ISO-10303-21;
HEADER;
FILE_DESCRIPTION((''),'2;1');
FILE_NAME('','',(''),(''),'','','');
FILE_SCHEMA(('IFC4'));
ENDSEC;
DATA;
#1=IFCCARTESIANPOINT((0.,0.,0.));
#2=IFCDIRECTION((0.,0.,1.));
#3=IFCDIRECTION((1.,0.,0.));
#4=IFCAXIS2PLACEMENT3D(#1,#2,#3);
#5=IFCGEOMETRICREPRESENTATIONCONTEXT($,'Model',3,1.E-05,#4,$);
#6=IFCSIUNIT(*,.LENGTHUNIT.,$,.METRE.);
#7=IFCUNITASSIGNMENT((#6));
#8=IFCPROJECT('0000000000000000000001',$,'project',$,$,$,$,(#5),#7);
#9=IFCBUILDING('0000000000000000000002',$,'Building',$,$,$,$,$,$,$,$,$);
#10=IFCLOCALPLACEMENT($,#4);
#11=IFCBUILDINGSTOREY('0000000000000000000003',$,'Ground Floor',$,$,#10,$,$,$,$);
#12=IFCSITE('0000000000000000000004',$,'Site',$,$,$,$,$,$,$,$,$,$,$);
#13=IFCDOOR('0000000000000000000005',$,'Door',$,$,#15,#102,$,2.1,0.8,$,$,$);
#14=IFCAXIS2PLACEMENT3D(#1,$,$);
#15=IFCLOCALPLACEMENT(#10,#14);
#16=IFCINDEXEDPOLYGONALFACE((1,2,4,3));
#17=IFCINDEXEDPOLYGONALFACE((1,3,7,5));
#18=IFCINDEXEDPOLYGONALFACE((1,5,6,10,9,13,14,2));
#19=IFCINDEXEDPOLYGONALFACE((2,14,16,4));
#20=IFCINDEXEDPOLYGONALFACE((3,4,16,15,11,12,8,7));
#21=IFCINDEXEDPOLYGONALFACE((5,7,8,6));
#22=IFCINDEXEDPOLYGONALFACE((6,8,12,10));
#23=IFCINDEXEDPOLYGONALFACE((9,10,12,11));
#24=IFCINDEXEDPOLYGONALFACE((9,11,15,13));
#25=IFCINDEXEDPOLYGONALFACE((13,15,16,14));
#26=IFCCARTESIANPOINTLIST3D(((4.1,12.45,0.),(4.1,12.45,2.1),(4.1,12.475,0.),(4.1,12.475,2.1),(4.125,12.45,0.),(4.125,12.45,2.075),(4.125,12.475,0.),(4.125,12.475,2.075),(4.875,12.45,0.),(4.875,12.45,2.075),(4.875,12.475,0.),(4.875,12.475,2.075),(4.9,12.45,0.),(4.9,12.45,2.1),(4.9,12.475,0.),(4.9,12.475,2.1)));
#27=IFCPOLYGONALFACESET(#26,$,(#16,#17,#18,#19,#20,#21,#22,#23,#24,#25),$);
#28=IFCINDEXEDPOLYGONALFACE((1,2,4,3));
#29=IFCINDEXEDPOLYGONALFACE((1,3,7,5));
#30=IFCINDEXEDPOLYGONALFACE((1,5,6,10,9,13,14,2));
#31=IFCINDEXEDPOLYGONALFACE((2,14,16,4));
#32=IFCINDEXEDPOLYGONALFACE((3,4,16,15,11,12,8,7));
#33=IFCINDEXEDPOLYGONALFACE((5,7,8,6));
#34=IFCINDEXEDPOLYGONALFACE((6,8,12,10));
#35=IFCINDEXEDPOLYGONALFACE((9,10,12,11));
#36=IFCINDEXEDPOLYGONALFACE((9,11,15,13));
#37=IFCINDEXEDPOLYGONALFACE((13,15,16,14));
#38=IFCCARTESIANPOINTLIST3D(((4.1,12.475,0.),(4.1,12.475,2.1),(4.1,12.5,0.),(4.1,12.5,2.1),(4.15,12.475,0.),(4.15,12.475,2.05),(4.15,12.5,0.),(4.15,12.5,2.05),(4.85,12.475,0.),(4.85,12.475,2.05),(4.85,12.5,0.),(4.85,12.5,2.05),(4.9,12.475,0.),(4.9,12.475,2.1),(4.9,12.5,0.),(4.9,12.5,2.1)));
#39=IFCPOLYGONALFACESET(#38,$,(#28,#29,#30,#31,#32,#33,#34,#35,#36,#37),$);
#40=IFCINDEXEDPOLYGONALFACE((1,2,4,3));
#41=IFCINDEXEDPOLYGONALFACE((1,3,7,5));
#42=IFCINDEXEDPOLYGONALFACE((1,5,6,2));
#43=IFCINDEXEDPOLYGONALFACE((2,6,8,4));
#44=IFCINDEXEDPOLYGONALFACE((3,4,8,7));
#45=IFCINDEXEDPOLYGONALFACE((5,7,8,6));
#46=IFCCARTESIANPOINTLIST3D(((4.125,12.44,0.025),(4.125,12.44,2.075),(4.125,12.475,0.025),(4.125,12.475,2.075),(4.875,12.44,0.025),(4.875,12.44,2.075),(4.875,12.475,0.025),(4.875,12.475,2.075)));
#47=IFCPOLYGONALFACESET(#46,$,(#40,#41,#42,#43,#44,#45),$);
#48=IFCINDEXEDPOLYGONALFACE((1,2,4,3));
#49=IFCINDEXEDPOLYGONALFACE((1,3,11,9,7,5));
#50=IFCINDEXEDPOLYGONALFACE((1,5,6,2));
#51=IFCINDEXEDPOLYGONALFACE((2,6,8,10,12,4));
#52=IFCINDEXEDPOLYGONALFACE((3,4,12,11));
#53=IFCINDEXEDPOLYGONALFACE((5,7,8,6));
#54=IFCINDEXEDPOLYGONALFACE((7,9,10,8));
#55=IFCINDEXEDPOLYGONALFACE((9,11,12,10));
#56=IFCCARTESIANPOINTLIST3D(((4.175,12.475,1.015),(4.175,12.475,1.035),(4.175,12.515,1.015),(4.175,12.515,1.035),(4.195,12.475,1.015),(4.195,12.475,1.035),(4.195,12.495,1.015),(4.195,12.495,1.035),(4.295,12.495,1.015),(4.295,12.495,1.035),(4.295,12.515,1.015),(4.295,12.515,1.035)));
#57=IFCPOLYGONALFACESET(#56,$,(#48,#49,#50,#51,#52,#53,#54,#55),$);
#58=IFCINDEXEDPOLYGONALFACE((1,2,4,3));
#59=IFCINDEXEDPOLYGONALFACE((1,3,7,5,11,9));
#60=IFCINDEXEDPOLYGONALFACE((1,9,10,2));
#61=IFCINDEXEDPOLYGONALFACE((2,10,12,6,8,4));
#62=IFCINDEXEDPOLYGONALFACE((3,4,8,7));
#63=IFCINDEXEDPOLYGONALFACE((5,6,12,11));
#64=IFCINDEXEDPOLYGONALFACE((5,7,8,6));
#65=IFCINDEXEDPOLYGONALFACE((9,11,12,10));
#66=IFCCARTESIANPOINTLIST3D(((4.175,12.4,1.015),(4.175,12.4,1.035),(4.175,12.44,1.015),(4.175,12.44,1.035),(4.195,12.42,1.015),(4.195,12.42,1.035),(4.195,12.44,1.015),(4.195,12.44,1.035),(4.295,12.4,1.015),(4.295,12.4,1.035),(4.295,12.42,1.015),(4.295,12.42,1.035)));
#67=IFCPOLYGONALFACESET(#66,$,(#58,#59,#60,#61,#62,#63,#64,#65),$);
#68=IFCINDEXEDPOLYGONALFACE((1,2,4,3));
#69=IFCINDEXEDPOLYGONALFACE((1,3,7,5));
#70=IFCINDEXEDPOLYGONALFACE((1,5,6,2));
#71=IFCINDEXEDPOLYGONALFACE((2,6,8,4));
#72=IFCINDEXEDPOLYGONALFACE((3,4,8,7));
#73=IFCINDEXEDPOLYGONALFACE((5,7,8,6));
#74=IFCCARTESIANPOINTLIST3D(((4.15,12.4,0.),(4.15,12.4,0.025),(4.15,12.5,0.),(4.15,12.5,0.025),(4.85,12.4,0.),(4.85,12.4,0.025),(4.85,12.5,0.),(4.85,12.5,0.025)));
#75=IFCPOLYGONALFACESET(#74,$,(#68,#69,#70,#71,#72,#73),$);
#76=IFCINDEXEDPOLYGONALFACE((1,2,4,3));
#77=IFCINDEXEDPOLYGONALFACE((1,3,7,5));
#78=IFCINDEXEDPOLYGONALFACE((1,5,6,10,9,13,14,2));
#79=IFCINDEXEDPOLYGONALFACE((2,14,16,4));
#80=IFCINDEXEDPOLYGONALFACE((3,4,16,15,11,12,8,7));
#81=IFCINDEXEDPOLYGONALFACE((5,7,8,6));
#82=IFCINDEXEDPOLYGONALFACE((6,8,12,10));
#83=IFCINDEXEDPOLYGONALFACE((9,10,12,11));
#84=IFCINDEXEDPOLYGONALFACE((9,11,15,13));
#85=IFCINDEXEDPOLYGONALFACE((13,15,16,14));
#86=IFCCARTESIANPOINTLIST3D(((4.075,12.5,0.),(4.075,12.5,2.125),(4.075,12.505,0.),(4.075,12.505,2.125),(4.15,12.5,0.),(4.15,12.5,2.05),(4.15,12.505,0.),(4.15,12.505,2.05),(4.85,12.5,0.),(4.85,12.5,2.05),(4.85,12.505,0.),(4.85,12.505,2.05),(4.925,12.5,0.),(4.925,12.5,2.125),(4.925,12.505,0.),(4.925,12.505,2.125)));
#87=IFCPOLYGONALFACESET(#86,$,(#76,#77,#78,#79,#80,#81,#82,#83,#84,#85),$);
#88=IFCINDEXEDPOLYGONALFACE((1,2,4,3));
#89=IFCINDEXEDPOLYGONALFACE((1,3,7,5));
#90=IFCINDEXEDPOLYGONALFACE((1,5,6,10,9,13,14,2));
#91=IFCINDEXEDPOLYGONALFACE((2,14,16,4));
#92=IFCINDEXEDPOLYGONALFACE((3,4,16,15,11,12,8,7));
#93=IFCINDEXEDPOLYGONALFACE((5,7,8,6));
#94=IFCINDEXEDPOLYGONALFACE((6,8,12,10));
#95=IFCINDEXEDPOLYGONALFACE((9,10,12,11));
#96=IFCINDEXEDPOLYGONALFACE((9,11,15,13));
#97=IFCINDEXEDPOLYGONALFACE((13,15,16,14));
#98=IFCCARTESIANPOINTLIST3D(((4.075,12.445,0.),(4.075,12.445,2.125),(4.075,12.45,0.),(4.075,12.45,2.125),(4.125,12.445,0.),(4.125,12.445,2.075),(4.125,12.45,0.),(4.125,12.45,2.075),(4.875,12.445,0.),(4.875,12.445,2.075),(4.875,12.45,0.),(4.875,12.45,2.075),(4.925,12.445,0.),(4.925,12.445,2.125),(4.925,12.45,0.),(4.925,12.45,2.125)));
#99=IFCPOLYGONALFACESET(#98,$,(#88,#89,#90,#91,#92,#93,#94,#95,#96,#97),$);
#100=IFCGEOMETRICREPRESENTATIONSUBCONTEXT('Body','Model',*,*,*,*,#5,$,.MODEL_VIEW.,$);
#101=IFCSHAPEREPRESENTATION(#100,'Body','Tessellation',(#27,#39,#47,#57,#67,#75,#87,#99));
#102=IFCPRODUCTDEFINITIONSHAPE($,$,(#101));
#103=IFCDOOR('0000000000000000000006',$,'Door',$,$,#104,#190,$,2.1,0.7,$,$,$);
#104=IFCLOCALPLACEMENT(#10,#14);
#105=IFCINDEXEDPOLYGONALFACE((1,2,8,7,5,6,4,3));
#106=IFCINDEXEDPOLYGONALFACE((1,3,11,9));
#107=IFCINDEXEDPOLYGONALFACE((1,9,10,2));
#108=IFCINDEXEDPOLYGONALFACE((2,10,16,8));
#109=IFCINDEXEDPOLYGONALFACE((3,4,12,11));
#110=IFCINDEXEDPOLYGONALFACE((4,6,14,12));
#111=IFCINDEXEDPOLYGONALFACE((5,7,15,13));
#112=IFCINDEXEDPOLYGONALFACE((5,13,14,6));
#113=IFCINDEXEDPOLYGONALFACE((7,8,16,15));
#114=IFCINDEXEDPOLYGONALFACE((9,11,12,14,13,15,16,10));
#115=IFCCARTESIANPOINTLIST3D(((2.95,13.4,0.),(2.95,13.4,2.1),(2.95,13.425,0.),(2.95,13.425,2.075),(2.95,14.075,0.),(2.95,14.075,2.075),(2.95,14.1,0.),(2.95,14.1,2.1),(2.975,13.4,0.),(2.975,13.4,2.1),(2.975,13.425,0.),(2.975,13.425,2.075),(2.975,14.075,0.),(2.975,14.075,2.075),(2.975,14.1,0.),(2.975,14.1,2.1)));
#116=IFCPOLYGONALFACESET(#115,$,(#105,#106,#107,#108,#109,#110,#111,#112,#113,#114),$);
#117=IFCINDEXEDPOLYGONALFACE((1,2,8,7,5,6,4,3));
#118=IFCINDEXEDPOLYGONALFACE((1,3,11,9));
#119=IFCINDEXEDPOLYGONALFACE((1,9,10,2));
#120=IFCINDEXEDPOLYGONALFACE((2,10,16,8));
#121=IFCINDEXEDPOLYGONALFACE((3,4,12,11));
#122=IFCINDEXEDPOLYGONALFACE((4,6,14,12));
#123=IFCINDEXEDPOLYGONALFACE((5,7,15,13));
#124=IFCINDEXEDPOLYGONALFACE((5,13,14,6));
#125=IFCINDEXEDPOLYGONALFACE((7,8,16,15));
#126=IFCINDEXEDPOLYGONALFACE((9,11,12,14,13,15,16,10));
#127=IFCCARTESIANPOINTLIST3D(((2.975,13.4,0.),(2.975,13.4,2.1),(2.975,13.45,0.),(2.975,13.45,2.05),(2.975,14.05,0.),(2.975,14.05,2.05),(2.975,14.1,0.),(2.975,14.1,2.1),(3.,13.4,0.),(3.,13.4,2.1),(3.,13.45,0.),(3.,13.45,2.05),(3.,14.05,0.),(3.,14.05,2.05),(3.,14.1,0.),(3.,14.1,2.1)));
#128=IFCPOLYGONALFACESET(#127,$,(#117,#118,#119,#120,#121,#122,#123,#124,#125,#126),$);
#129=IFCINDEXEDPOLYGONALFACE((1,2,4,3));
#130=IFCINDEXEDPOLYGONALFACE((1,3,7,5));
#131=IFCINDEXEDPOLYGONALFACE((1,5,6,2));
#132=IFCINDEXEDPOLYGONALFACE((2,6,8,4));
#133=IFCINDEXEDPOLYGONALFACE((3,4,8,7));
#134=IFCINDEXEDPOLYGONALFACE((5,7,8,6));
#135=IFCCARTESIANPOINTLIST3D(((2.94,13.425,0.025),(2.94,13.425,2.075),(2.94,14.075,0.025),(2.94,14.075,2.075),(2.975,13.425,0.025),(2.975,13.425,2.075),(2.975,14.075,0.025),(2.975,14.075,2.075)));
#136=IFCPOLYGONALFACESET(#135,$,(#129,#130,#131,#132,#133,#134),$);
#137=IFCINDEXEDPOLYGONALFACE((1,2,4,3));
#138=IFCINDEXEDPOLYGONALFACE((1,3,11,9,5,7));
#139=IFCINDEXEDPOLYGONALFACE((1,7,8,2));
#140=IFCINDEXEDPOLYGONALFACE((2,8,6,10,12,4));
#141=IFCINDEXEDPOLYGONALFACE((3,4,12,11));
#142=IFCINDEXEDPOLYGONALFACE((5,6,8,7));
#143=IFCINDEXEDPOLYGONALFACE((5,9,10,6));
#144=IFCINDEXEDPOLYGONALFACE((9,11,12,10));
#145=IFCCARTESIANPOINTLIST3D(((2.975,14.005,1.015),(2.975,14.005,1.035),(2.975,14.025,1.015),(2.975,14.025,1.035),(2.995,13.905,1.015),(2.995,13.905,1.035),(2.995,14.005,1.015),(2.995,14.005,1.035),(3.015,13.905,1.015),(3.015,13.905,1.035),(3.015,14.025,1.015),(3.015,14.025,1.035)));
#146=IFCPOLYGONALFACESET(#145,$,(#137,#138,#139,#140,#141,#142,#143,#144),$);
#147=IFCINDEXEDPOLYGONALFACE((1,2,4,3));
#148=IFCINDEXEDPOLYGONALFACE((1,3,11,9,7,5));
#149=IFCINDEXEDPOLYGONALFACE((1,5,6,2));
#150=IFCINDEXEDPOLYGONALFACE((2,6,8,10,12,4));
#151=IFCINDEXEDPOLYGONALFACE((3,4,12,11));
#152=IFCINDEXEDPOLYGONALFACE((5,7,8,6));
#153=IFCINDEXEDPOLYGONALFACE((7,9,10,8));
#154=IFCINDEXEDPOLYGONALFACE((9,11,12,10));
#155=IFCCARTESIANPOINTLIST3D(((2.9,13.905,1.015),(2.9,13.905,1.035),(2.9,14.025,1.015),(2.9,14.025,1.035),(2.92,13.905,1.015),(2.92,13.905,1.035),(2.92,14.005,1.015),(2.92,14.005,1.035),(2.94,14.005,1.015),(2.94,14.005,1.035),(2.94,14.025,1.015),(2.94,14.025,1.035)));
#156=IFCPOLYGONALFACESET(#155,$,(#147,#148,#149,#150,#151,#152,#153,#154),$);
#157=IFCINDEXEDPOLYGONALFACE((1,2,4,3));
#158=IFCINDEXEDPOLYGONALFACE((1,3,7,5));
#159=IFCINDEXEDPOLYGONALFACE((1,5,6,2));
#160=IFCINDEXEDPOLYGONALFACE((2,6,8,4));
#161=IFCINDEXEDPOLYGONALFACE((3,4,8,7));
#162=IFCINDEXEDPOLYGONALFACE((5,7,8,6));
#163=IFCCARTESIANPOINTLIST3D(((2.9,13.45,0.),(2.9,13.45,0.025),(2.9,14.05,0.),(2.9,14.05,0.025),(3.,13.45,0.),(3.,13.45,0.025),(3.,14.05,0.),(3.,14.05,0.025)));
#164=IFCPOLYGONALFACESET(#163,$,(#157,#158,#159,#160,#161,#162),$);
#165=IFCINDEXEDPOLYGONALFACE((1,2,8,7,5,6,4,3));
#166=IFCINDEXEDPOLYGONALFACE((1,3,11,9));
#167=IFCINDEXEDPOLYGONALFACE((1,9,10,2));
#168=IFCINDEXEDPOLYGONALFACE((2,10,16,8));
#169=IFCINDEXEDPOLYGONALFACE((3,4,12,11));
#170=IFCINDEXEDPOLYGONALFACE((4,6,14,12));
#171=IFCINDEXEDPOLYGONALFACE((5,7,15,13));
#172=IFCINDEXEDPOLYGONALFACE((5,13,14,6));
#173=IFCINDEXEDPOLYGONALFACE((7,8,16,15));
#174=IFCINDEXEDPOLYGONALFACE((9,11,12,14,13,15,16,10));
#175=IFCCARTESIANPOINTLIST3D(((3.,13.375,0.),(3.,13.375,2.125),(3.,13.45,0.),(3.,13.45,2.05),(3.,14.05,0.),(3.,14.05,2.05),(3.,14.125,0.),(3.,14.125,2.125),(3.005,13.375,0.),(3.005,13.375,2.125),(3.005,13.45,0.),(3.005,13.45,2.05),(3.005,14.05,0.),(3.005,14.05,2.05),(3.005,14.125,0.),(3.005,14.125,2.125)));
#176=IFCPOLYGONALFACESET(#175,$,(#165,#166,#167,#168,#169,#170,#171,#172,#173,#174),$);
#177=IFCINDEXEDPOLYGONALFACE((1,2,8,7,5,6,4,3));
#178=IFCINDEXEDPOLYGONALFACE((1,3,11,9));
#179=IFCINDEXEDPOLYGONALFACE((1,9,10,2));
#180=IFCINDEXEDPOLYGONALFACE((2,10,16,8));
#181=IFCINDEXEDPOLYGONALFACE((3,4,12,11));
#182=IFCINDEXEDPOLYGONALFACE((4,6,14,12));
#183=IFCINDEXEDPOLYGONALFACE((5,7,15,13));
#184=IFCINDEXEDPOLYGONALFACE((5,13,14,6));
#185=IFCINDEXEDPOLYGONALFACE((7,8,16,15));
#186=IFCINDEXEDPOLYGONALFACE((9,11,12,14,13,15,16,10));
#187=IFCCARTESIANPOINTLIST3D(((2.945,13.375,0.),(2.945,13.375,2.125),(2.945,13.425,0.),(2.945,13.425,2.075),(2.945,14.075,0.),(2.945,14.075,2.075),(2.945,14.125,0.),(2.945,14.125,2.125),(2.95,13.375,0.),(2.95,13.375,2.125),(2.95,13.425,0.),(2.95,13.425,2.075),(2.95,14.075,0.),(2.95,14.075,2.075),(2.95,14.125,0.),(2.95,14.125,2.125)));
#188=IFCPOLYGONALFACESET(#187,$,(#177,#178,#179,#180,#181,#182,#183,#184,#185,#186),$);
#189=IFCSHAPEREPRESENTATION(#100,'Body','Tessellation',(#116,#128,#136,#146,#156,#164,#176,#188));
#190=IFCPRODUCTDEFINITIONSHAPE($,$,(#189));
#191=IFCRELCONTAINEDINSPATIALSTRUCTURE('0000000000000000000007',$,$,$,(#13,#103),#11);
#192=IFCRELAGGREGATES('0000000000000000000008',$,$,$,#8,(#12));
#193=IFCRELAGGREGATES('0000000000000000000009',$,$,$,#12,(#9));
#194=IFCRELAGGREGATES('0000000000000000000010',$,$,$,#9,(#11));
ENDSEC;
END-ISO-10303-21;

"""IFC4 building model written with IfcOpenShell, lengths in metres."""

from ifc_helpers import new_model, si_unit, frame, origin_with_axes, place, context, subcontext, project, spatial, line, indexed_curve, outline, extrude, element, save


model = new_model("IFC4")

# Units and contexts
model_context = context("Model", 3, precision=1e-05, world=origin_with_axes())
body_context = subcontext(model_context, "Body", "Model", "MODEL_VIEW")
ifc_project = project(units=[si_unit("LENGTHUNIT", "METRE")], contexts=[model_context])

# Site, building, storey
site = spatial("IfcSite", under=ifc_project, Name="Site")
building = spatial("IfcBuilding", under=site, Name="Building")
storey_placement = place(None, origin_with_axes())
storey = spatial("IfcBuildingStorey", under=building, at=storey_placement, Name="Ground Floor")

# Doors
door_1_placement = place(storey_placement, frame((4.9, 12.5, 0.0), z_axis=(0.0, 0.0, 1.0), x_axis=(-1.0, 0.0, 0.0)))
element("IfcDoor", 1, at=door_1_placement, inside=storey, Name="Door", OverallHeight=2.1, OverallWidth=0.8, context=body_context, shape_type="SweptSolid", body=[
    extrude(outline(indexed_curve([(0.0, 0.0), (0.0, 2.1), (0.8, 2.1), (0.8, 0.0), (0.775, 0.0), (0.775, 2.075), (0.025, 2.075), (0.025, 0.0)], segments=[line(1, 2, 3, 4, 5, 6, 7, 8, 1)])), frame((0.0, 0.025, 0.0), z_axis=(0.0, -1.0, 0.0), x_axis=(1.0, 0.0, 0.0)), (0.0, 0.0, -1.0), 0.025),
    extrude(outline(indexed_curve([(0.0, 0.0), (0.0, 2.1), (0.8, 2.1), (0.8, 0.0), (0.75, 0.0), (0.75, 2.05), (0.05, 2.05), (0.05, 0.0)], segments=[line(1, 2, 3, 4, 5, 6, 7, 8, 1)])), frame((0.0, 0.0, 0.0), z_axis=(0.0, -1.0, 0.0), x_axis=(1.0, 0.0, 0.0)), (0.0, 0.0, -1.0), 0.025),
    extrude(outline(indexed_curve([(0.0, 0.0), (0.75, 0.0), (0.75, 0.035), (0.0, 0.035)], segments=[line(1, 2, 3, 4, 1)])), frame((0.025, 0.025, 0.025), z_axis=(0.0, 0.0, 1.0), x_axis=(1.0, 0.0, 0.0)), (0.0, 0.0, 1.0), 2.05),
    extrude(outline(indexed_curve([(0.0, 0.0), (0.0, -0.04), (-0.12, -0.04), (-0.12, -0.02), (-0.02, -0.02), (-0.02, 0.0)], segments=[line(1, 2, 3, 4, 5, 6, 1)])), frame((0.725, 0.025, 1.015), z_axis=(0.0, 0.0, 1.0), x_axis=(1.0, 0.0, 0.0)), (0.0, 0.0, 1.0), 0.02),
    extrude(outline(indexed_curve([(0.0, 0.0), (0.0, 0.04), (-0.12, 0.04), (-0.12, 0.02), (-0.02, 0.02), (-0.02, 0.0)], segments=[line(1, 2, 3, 4, 5, 6, 1)])), frame((0.725, 0.06, 1.015), z_axis=(0.0, 0.0, 1.0), x_axis=(1.0, 0.0, 0.0)), (0.0, 0.0, 1.0), 0.02),
    extrude(outline(indexed_curve([(0.0, 0.0), (0.7, 0.0), (0.7, 0.1), (0.0, 0.1)], segments=[line(1, 2, 3, 4, 1)])), frame((0.05, 0.0, 0.0), z_axis=(0.0, 0.0, 1.0), x_axis=(1.0, 0.0, 0.0)), (0.0, 0.0, 1.0), 0.025),
    extrude(outline(indexed_curve([(0.0, 0.0), (0.0, 2.125), (0.85, 2.125), (0.85, 0.0), (0.775, 0.0), (0.775, 2.05), (0.075, 2.05), (0.075, 0.0)], segments=[line(1, 2, 3, 4, 5, 6, 7, 8, 1)])), frame((-0.025, -0.005, 0.0), z_axis=(0.0, -1.0, 0.0), x_axis=(1.0, 0.0, 0.0)), (0.0, 0.0, -1.0), 0.005),
    extrude(outline(indexed_curve([(0.0, 0.0), (0.0, 2.125), (0.85, 2.125), (0.85, 0.0), (0.8, 0.0), (0.8, 2.075), (0.05, 2.075), (0.05, 0.0)], segments=[line(1, 2, 3, 4, 5, 6, 7, 8, 1)])), frame((-0.025, 0.05, 0.0), z_axis=(0.0, -1.0, 0.0), x_axis=(1.0, 0.0, 0.0)), (0.0, 0.0, -1.0), 0.005),
])
door_2_placement = place(storey_placement, frame((3.0, 13.4, 0.0), z_axis=(0.0, 0.0, 1.0), x_axis=(0.0, 1.0, 0.0)))
element("IfcDoor", 2, at=door_2_placement, inside=storey, Name="Door", OverallHeight=2.1, OverallWidth=0.7, context=body_context, shape_type="SweptSolid", body=[
    extrude(outline(indexed_curve([(0.0, 0.0), (0.0, 2.1), (0.7, 2.1), (0.7, 0.0), (0.675, 0.0), (0.675, 2.075), (0.025, 2.075), (0.025, 0.0)], segments=[line(1, 2, 3, 4, 5, 6, 7, 8, 1)])), frame((0.0, 0.025, 0.0), z_axis=(0.0, -1.0, 0.0), x_axis=(1.0, 0.0, 0.0)), (0.0, 0.0, -1.0), 0.025),
    extrude(outline(indexed_curve([(0.0, 0.0), (0.0, 2.1), (0.7, 2.1), (0.7, 0.0), (0.65, 0.0), (0.65, 2.05), (0.05, 2.05), (0.05, 0.0)], segments=[line(1, 2, 3, 4, 5, 6, 7, 8, 1)])), frame((0.0, 0.0, 0.0), z_axis=(0.0, -1.0, 0.0), x_axis=(1.0, 0.0, 0.0)), (0.0, 0.0, -1.0), 0.025),
    extrude(outline(indexed_curve([(0.0, 0.0), (0.65, 0.0), (0.65, 0.035), (0.0, 0.035)], segments=[line(1, 2, 3, 4, 1)])), frame((0.025, 0.025, 0.025), z_axis=(0.0, 0.0, 1.0), x_axis=(1.0, 0.0, 0.0)), (0.0, 0.0, 1.0), 2.05),
    extrude(outline(indexed_curve([(0.0, 0.0), (0.0, -0.04), (-0.12, -0.04), (-0.12, -0.02), (-0.02, -0.02), (-0.02, 0.0)], segments=[line(1, 2, 3, 4, 5, 6, 1)])), frame((0.625, 0.025, 1.015), z_axis=(0.0, 0.0, 1.0), x_axis=(1.0, 0.0, 0.0)), (0.0, 0.0, 1.0), 0.02),
    extrude(outline(indexed_curve([(0.0, 0.0), (0.0, 0.04), (-0.12, 0.04), (-0.12, 0.02), (-0.02, 0.02), (-0.02, 0.0)], segments=[line(1, 2, 3, 4, 5, 6, 1)])), frame((0.625, 0.06, 1.015), z_axis=(0.0, 0.0, 1.0), x_axis=(1.0, 0.0, 0.0)), (0.0, 0.0, 1.0), 0.02),
    extrude(outline(indexed_curve([(0.0, 0.0), (0.6, 0.0), (0.6, 0.1), (0.0, 0.1)], segments=[line(1, 2, 3, 4, 1)])), frame((0.05, 0.0, 0.0), z_axis=(0.0, 0.0, 1.0), x_axis=(1.0, 0.0, 0.0)), (0.0, 0.0, 1.0), 0.025),
    extrude(outline(indexed_curve([(0.0, 0.0), (0.0, 2.125), (0.75, 2.125), (0.75, 0.0), (0.675, 0.0), (0.675, 2.05), (0.075, 2.05), (0.075, 0.0)], segments=[line(1, 2, 3, 4, 5, 6, 7, 8, 1)])), frame((-0.025, -0.005, 0.0), z_axis=(0.0, -1.0, 0.0), x_axis=(1.0, 0.0, 0.0)), (0.0, 0.0, -1.0), 0.005),
    extrude(outline(indexed_curve([(0.0, 0.0), (0.0, 2.125), (0.75, 2.125), (0.75, 0.0), (0.7, 0.0), (0.7, 2.075), (0.05, 2.075), (0.05, 0.0)], segments=[line(1, 2, 3, 4, 5, 6, 7, 8, 1)])), frame((-0.025, 0.05, 0.0), z_axis=(0.0, -1.0, 0.0), x_axis=(1.0, 0.0, 0.0)), (0.0, 0.0, -1.0), 0.005),
])

save(model, "model.ifc")
